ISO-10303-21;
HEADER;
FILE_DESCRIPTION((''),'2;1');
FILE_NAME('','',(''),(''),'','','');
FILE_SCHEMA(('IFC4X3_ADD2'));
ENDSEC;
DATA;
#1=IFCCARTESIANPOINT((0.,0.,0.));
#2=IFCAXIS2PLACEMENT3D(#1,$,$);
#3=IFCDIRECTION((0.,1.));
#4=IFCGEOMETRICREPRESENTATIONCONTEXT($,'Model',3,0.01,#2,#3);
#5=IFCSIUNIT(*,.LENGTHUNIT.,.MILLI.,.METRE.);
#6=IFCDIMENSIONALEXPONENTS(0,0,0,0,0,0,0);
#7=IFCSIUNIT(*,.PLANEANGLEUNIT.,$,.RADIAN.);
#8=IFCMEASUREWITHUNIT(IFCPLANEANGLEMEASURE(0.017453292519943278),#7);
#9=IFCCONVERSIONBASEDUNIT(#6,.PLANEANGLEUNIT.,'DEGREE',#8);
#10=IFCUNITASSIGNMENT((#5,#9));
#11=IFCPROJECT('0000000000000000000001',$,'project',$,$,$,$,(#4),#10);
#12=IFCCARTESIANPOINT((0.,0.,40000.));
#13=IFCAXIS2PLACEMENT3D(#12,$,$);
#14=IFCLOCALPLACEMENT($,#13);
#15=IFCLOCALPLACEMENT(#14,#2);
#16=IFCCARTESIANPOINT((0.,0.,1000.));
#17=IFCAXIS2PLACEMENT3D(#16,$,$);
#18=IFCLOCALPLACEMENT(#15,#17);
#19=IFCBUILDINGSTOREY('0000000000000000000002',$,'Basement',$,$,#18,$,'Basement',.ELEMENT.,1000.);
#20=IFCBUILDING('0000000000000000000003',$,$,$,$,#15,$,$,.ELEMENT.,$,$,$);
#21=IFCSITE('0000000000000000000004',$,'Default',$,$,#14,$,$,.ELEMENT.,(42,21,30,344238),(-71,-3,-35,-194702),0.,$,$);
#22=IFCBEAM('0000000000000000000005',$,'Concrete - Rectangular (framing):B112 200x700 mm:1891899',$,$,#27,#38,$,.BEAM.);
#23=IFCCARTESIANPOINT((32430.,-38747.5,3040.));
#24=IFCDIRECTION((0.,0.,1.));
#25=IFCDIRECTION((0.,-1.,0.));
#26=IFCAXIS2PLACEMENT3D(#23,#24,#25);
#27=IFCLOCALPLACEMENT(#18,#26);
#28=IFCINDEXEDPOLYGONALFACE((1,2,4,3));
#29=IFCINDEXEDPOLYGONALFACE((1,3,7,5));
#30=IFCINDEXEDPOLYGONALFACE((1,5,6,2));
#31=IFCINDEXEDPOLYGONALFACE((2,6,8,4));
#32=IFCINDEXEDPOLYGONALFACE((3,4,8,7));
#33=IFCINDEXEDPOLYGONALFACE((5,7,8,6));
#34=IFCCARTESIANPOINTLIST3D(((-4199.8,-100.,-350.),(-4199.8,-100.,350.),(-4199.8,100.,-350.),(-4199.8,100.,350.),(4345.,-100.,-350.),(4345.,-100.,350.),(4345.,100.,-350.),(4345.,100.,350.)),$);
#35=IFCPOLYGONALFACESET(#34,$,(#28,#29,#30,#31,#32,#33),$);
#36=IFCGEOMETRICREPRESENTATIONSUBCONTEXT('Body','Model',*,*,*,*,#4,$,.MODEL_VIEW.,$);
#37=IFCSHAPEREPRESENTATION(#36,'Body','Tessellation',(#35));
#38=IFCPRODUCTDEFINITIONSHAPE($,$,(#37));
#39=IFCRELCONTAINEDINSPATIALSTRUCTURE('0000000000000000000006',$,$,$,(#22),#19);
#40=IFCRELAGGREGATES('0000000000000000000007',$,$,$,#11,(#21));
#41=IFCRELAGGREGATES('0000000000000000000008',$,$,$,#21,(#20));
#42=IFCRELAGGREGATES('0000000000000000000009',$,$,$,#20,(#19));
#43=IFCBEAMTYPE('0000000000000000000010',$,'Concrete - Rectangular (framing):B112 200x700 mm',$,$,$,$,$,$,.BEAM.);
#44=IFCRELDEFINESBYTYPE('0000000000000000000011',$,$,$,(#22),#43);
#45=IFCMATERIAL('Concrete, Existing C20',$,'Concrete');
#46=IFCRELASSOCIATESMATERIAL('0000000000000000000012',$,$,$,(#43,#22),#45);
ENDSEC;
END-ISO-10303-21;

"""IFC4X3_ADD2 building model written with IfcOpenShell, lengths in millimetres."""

from ifc_helpers import new_model, entity, si_unit, converted_unit, direction, frame, origin, origin_2d_with_axis, place, context, subcontext, project, spatial, rectangle, extrude, source, transform, mapped, material, material_profile, profile_set, profile_usage, type_object, type_shapes, element, save


model = new_model("IFC4X3_ADD2")

# Units and contexts
model_context = context("Model", 3, precision=0.01, world=origin(), true_north=direction((0.0, 1.0)))
body_context = subcontext(model_context, "Body", "Model", "MODEL_VIEW")
ifc_project = project(units=[si_unit("LENGTHUNIT", "METRE", prefix="MILLI"), converted_unit("PLANEANGLEUNIT", "DEGREE", entity("IfcPlaneAngleMeasure", 0.017453292519943278), si_unit("PLANEANGLEUNIT", "RADIAN"), dimensions=[0, 0, 0, 0, 0, 0, 0])], contexts=[model_context])

# Site, building, storey
site_placement = place(None, frame((0.0, 0.0, 40000.0)))
site = spatial("IfcSite", under=ifc_project, at=site_placement, Name="Default", CompositionType="ELEMENT", RefLatitude=(42, 21, 30, 344238), RefLongitude=(-71, -3, -35, -194702), RefElevation=0.0)
building_placement = place(site_placement, origin())
building = spatial("IfcBuilding", under=site, at=building_placement, CompositionType="ELEMENT")
storey_placement = place(building_placement, frame((0.0, 0.0, 1000.0)))
storey = spatial("IfcBuildingStorey", under=building, at=storey_placement, Name="Basement", LongName="Basement", CompositionType="ELEMENT", Elevation=1000.0)

# Shared definitions
ifc_material_1 = material(Name="Concrete, Existing C20", Category="Concrete")

# Beam
ifc_material_profile_1 = material_profile(ifc_material_1, rectangle(XDim=8579.8, YDim=200.0, at=origin_2d_with_axis()), Name="B112 200x700 mm")
ifc_profile_set_1 = profile_set([ifc_material_profile_1], Name="B112 200x700 mm")
ifc_profile_usage_1 = profile_usage(ifc_profile_set_1, cardinal=8)
beam_type_1 = type_object("IfcBeamType", Name="Concrete - Rectangular (framing):B112 200x700 mm", PredefinedType="BEAM", material=ifc_profile_set_1)
shared_shape_1 = source(origin(), body_context, "Body", "SweptSolid", [
    extrude(rectangle(XDim=8544.8, YDim=200.0, at=origin_2d_with_axis()), frame((72.6, 0.0, -350.0), z_axis=(0.0, 0.0, 1.0), x_axis=(-1.0, 0.0, 0.0)), (0.0, 0.0, 1.0), 700.0),
])
type_shapes(beam_type_1, [shared_shape_1])
beam_1_placement = place(storey_placement, frame((32430.0, -38747.5, 3040.0), z_axis=(0.0, 0.0, 1.0), x_axis=(0.0, -1.0, 0.0)))
element("IfcBeam", 1, at=beam_1_placement, inside=storey, type_object=beam_type_1, material=ifc_profile_usage_1, Name="Concrete - Rectangular (framing):B112 200x700 mm:1891899", PredefinedType="BEAM", context=body_context, shape_type="MappedRepresentation", body=[
    mapped(shared_shape_1, transform((0.0, 0.0, 0.0), scale=1.0)),
])

save(model, "model.ifc")
